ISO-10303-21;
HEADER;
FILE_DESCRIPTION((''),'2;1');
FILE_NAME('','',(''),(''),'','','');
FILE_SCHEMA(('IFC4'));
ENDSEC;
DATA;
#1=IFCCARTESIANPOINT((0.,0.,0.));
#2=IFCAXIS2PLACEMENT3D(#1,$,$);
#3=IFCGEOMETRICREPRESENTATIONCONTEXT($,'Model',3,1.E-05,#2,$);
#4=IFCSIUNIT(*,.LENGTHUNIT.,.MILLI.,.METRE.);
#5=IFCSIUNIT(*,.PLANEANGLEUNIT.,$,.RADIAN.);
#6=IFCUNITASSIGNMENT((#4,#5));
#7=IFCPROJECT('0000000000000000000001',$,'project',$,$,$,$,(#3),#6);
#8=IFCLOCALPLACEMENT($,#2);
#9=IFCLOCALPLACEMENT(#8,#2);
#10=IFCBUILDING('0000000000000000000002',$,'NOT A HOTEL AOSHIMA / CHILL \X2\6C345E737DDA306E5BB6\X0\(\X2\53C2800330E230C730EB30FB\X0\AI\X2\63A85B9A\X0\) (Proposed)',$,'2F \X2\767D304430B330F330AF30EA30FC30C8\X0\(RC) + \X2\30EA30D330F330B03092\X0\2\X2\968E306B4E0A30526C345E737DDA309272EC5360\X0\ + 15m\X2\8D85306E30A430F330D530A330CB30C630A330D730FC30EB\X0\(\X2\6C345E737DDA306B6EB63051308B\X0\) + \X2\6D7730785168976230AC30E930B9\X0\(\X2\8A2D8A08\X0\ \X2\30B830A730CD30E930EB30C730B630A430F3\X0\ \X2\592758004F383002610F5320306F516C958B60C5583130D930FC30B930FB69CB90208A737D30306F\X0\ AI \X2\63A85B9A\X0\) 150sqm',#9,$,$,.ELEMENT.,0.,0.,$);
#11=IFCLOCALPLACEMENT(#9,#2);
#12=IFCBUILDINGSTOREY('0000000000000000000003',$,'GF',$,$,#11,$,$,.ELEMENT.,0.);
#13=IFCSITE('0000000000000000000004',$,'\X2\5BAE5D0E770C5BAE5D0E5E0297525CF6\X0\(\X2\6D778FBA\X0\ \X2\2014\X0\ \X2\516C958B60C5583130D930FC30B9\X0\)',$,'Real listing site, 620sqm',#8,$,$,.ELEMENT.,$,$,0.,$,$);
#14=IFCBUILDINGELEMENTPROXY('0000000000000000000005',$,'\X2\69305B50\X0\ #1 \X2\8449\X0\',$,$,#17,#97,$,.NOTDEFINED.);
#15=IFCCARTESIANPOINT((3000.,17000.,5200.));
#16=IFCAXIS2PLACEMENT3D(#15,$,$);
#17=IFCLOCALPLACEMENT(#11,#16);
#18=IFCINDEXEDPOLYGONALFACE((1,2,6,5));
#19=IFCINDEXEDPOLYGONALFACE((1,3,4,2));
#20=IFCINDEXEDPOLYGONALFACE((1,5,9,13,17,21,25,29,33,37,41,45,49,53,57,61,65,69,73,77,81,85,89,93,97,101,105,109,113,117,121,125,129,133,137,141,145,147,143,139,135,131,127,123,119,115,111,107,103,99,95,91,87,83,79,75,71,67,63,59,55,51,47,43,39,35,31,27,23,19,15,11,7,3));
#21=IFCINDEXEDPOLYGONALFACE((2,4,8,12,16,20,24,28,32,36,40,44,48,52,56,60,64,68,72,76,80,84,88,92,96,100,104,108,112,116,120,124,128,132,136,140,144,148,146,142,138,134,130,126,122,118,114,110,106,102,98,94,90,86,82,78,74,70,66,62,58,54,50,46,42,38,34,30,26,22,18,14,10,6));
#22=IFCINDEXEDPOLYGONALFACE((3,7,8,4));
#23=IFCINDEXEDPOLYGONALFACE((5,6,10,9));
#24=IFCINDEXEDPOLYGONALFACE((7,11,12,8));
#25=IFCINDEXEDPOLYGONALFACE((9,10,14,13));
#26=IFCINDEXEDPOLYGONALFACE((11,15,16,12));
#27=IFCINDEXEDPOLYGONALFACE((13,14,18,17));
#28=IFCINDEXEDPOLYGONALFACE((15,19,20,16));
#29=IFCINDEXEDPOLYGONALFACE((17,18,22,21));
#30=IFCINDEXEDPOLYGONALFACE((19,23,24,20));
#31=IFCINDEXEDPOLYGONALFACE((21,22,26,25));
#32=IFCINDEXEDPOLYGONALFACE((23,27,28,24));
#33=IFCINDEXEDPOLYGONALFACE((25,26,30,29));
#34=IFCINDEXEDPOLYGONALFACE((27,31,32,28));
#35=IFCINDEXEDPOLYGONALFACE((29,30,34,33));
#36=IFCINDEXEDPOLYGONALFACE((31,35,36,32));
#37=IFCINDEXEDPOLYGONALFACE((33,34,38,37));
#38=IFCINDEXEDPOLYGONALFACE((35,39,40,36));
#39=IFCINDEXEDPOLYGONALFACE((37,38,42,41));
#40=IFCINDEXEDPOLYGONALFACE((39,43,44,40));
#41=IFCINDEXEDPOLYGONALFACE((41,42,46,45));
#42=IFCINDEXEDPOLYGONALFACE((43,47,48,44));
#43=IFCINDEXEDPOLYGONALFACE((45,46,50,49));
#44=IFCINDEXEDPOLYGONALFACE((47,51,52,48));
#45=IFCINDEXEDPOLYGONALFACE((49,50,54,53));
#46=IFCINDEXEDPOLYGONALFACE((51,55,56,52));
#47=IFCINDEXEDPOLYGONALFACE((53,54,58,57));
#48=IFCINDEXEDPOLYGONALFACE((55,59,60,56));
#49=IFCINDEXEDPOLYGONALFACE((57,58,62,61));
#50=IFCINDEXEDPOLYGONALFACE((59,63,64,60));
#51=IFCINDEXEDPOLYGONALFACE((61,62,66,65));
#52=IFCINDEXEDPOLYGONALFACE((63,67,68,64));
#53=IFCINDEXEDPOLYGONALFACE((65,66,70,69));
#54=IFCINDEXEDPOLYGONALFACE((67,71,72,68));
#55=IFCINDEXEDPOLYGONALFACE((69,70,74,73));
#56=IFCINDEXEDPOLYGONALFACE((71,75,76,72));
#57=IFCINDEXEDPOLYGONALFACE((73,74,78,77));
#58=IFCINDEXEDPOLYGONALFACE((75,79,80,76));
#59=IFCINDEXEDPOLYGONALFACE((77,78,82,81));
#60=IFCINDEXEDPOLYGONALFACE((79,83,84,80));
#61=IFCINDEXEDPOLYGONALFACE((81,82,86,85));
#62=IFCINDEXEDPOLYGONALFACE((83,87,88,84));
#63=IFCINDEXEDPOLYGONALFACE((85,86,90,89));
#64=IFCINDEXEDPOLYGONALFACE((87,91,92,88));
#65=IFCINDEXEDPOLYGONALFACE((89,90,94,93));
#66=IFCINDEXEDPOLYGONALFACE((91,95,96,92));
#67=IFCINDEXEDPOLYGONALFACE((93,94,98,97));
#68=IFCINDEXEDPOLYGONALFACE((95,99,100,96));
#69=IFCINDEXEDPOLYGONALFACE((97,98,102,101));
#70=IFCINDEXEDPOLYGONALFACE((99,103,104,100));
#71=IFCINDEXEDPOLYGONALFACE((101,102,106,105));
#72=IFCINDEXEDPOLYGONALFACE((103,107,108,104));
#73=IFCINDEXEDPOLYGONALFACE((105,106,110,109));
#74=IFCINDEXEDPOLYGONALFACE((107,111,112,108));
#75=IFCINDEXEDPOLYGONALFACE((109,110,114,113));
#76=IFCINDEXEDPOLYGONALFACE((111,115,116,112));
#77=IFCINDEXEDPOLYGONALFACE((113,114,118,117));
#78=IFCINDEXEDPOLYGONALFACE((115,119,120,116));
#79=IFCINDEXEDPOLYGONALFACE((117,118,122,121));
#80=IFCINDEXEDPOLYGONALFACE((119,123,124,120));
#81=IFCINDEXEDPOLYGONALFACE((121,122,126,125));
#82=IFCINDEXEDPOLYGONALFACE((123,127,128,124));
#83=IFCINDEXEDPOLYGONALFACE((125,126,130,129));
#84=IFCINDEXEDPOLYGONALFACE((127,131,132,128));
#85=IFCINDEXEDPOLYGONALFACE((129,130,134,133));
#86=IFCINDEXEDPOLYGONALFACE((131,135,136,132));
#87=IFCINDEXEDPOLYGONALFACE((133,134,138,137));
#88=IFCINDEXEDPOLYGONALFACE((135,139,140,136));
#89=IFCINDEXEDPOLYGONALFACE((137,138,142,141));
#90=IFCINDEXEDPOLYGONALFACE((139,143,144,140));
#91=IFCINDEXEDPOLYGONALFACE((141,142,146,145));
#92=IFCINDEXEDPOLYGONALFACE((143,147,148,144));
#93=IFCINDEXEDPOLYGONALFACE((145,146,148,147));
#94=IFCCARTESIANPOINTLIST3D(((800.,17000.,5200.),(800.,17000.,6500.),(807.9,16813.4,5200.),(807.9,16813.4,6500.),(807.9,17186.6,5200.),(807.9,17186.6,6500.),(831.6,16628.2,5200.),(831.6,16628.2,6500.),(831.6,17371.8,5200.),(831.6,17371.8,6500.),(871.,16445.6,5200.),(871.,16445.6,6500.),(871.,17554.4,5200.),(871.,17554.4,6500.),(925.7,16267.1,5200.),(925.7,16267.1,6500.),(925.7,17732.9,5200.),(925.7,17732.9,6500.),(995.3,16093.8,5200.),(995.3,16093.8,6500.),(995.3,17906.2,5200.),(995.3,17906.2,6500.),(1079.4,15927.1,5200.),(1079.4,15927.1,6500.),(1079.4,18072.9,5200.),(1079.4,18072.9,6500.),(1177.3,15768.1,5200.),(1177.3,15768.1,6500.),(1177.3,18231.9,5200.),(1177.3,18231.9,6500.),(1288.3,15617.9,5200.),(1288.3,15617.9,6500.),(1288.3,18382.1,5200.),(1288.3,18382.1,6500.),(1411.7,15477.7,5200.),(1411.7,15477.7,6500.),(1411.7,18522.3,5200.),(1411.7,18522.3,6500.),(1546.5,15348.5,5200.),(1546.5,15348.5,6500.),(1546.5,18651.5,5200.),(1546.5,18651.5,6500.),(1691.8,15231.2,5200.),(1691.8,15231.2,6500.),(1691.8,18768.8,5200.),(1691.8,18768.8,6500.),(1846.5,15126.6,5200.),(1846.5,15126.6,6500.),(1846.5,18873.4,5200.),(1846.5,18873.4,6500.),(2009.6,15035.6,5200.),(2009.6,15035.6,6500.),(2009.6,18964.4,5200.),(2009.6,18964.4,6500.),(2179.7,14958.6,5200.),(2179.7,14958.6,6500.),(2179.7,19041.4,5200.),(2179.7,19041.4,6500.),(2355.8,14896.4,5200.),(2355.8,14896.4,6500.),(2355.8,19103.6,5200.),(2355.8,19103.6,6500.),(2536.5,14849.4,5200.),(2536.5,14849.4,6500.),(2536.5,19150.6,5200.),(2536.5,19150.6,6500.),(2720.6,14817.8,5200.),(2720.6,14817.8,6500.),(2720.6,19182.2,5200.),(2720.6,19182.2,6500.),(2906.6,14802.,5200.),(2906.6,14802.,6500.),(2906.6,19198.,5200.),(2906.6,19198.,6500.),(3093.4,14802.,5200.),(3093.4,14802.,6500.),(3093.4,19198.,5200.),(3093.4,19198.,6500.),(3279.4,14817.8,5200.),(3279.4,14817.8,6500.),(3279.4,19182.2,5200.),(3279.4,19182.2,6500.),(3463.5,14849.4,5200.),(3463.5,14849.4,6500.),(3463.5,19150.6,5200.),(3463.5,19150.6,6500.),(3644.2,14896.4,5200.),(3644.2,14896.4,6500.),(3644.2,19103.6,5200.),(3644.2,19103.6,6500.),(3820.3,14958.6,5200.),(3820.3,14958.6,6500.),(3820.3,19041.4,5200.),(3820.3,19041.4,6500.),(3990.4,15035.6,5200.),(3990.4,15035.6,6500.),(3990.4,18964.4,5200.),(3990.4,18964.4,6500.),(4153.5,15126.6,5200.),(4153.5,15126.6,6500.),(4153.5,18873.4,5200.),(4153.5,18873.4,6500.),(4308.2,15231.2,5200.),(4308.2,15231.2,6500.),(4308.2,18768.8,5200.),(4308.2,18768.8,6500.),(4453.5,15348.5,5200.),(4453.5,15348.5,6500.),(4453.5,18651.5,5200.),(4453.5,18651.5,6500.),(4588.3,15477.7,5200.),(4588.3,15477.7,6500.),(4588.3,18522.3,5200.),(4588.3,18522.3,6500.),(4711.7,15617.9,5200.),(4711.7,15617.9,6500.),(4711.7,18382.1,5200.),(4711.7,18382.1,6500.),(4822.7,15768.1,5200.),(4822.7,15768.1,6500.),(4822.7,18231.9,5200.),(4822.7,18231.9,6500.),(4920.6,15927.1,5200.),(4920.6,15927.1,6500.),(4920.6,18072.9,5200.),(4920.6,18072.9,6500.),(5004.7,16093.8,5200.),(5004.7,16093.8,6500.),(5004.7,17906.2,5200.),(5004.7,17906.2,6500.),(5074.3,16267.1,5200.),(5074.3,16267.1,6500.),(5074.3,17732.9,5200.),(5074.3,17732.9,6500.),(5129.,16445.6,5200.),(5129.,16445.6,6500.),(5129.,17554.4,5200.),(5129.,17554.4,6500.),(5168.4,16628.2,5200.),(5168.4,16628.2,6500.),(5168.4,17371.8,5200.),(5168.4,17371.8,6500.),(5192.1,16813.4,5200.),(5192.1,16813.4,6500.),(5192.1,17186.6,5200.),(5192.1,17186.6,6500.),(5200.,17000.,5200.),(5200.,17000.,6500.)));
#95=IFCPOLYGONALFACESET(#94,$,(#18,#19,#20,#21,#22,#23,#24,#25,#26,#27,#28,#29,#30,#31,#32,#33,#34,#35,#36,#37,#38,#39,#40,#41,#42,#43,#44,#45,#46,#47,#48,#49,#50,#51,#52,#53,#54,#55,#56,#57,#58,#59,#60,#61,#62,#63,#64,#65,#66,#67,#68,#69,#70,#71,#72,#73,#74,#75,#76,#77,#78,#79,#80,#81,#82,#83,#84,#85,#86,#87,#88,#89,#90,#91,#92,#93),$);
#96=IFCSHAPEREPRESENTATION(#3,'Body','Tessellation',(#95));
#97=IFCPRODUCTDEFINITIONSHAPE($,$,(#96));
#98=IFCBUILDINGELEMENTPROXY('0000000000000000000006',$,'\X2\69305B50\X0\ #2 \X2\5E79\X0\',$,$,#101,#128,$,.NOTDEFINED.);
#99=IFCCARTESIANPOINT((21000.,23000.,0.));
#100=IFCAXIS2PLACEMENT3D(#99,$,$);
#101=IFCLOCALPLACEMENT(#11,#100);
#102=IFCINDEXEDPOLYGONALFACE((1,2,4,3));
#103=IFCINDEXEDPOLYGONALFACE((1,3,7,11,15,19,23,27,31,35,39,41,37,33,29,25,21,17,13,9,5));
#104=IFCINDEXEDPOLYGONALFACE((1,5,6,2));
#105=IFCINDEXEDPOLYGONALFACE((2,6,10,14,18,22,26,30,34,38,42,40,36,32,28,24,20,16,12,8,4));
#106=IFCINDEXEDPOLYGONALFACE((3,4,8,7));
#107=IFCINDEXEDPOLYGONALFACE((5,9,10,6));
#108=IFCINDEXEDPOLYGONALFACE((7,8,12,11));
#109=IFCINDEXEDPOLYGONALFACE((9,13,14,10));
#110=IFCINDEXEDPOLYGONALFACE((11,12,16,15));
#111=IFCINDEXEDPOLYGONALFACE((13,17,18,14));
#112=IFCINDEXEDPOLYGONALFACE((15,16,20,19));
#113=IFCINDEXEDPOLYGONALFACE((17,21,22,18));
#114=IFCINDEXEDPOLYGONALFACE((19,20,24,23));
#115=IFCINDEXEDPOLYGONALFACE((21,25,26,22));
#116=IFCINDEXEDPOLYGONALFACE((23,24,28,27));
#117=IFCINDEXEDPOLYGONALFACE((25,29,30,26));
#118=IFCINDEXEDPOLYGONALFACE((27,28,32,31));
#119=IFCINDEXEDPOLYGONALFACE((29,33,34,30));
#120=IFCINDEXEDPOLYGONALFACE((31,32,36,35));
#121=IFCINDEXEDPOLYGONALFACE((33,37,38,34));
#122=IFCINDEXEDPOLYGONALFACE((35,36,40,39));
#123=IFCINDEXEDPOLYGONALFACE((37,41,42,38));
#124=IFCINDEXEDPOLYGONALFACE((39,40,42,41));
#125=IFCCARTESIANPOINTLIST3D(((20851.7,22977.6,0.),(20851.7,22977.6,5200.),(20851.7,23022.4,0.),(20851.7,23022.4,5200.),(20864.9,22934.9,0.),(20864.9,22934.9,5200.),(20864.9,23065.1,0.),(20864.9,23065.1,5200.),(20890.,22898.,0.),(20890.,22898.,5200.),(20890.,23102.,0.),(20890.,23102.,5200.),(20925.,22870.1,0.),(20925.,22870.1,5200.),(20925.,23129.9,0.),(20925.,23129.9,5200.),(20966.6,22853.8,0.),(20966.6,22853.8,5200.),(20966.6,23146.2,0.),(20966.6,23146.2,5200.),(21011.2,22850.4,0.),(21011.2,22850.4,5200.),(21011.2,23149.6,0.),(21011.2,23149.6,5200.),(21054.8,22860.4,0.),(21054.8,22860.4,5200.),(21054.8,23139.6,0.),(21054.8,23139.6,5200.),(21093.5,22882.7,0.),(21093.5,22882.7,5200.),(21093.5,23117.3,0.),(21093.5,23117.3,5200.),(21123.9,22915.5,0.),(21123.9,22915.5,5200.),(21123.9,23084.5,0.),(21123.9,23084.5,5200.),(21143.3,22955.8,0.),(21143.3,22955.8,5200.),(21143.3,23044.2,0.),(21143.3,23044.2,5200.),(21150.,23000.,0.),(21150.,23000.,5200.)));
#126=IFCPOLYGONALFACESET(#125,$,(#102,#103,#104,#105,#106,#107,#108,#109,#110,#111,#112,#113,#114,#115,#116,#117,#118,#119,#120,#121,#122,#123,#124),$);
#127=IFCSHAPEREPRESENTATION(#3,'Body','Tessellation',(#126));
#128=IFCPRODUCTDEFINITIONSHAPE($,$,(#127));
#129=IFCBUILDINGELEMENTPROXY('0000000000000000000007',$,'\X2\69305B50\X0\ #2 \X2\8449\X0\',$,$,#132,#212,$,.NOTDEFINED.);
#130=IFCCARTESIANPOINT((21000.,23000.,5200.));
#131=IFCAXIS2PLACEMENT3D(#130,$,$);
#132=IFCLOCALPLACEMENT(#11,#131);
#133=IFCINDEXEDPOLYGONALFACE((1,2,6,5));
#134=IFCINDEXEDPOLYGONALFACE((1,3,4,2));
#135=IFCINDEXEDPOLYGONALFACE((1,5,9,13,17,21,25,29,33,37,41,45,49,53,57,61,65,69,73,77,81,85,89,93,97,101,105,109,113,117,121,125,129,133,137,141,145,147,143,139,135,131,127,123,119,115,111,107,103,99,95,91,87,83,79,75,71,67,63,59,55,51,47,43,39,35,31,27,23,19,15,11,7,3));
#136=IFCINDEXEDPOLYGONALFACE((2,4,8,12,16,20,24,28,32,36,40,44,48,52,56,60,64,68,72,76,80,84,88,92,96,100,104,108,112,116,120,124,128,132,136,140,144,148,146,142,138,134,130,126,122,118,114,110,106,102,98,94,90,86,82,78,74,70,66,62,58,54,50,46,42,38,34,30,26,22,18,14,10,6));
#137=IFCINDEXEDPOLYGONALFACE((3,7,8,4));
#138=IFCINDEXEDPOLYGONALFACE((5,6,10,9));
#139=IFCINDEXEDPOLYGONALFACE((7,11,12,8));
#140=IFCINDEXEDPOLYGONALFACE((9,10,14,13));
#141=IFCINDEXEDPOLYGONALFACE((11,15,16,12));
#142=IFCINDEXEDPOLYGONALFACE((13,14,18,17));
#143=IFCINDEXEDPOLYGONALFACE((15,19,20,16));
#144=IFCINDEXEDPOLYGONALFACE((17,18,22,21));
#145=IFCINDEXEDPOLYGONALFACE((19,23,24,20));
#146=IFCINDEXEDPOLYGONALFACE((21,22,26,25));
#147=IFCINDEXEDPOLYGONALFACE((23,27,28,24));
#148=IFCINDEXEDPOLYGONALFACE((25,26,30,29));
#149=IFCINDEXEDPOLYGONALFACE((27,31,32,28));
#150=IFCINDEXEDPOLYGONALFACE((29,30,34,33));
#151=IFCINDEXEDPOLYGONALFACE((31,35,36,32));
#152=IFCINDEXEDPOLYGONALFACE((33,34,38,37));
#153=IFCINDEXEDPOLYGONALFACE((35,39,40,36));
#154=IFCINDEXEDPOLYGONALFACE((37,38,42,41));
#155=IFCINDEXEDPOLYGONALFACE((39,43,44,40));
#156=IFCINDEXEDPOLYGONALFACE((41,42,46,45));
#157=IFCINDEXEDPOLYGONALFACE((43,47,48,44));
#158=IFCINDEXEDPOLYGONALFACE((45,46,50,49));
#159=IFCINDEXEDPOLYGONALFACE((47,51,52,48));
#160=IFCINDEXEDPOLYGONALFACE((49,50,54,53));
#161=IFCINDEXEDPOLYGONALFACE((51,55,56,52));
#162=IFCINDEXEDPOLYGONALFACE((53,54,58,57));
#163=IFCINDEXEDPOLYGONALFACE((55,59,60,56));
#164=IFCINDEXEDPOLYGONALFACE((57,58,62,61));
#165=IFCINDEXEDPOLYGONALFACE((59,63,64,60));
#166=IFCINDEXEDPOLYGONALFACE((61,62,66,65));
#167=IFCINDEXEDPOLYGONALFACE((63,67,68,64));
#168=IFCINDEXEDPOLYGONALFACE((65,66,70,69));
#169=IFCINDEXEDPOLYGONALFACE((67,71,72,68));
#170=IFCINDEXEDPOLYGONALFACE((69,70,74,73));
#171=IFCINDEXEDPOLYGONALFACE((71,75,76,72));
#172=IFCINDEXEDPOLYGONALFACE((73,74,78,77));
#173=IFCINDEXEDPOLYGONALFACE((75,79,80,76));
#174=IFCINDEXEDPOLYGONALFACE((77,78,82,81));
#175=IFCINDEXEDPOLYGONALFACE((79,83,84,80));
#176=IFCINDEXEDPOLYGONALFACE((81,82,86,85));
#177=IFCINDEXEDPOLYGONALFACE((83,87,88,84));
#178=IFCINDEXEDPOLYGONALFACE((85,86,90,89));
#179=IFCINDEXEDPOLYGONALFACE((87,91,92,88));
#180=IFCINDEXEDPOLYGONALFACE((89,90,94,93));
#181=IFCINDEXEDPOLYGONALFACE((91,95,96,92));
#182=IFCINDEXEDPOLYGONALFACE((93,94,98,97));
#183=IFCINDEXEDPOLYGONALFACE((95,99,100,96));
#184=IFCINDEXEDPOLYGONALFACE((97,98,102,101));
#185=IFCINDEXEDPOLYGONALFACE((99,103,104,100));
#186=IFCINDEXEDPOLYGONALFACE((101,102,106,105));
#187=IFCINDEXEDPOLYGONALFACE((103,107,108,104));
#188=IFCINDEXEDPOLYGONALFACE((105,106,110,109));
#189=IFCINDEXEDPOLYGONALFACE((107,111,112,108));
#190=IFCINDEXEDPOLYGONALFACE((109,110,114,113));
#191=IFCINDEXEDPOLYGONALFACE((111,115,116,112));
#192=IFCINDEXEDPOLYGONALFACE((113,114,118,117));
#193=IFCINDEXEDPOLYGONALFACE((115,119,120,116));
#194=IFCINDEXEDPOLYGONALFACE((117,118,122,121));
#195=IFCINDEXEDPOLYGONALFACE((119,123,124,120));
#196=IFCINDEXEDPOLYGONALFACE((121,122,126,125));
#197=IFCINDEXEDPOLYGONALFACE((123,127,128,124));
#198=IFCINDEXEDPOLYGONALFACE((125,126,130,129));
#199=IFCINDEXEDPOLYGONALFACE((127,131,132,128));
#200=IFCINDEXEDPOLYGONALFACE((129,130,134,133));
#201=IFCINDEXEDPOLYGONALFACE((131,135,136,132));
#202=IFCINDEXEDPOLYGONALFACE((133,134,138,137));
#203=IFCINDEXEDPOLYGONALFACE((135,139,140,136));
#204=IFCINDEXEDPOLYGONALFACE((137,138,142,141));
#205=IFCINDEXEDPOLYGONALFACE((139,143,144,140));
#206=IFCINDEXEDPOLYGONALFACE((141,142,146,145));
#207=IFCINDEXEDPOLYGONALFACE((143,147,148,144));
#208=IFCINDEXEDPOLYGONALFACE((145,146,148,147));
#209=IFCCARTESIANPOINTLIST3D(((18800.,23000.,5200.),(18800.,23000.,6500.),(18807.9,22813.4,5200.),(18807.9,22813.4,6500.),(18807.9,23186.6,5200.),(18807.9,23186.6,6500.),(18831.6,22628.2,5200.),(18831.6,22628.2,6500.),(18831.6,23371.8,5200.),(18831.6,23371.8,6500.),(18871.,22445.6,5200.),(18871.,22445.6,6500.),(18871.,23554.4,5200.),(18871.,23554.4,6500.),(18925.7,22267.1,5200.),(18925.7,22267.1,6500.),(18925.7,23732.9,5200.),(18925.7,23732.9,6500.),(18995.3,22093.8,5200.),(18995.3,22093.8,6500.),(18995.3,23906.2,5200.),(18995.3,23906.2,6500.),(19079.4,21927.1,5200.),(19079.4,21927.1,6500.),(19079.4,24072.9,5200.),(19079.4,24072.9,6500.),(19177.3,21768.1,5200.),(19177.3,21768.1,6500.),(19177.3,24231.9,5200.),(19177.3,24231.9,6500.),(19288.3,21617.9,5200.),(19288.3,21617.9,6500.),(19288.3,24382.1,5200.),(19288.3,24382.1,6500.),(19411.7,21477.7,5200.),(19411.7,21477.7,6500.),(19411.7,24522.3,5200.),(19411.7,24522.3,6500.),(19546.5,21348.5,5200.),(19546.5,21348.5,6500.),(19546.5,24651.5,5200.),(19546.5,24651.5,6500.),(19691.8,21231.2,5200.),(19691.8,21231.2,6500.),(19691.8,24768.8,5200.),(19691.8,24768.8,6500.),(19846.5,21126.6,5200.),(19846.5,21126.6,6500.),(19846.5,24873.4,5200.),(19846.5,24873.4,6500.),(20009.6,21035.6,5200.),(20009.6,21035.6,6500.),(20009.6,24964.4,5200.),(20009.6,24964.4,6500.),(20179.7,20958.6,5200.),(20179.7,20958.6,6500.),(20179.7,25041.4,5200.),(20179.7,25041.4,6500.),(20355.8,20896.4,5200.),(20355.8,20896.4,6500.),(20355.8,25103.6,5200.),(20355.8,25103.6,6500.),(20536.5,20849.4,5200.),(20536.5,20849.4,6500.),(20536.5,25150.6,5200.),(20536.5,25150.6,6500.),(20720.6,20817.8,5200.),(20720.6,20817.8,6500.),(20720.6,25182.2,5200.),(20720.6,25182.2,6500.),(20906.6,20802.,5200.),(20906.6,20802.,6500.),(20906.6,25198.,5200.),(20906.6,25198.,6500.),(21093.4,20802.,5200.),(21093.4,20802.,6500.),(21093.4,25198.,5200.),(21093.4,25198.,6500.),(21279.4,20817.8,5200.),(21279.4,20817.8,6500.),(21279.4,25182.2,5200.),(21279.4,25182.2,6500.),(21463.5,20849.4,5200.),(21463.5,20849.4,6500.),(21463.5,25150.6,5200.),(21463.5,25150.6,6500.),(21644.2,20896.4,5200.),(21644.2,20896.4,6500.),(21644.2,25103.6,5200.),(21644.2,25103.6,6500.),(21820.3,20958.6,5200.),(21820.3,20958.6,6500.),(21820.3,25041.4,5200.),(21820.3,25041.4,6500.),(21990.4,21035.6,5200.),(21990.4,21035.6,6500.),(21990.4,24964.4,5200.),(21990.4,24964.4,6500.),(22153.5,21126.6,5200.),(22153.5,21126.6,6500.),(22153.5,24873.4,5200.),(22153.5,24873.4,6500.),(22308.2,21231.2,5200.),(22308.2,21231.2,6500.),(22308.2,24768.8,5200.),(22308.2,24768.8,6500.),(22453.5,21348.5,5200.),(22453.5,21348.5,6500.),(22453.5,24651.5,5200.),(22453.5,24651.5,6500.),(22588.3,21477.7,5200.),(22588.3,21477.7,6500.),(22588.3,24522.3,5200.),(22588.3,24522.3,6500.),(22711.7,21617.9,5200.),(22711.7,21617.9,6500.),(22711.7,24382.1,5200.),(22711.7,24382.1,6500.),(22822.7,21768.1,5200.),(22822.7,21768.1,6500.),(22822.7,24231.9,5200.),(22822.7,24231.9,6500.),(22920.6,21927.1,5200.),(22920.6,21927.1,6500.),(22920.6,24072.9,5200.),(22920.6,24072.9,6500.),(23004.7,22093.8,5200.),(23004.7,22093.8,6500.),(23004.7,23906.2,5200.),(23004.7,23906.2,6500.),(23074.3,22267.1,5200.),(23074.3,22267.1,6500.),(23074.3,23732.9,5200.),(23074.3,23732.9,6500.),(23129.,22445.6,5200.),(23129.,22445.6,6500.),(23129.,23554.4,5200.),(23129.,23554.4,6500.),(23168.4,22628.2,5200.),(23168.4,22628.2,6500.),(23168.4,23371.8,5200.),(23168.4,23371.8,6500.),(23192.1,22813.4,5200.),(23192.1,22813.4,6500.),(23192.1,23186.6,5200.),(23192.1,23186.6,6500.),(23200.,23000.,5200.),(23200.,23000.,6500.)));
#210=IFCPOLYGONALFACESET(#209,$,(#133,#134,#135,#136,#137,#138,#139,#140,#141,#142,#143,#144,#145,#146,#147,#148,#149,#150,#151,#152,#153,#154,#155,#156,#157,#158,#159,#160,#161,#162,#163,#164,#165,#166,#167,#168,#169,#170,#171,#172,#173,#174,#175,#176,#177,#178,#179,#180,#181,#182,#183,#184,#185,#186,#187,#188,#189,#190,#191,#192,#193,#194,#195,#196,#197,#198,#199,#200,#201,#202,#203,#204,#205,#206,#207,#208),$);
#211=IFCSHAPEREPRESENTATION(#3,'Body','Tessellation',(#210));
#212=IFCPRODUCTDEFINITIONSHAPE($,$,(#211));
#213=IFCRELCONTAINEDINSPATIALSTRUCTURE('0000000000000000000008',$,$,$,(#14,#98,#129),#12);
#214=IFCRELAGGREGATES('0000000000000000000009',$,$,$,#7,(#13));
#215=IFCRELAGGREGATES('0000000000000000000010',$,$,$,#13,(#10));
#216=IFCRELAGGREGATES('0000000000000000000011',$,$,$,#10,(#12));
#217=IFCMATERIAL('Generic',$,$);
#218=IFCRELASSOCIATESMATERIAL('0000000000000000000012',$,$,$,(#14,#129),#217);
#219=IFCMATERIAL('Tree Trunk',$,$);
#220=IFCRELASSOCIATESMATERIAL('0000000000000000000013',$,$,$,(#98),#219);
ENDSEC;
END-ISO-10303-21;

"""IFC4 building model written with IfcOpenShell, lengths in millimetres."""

from ifc_helpers import new_model, si_unit, frame, origin, origin_2d, place, context, project, spatial, circle, extrude, material, element, save


model = new_model("IFC4")

# Units and contexts
model_context = context("Model", 3, precision=1e-05, world=origin())
ifc_project = project(units=[si_unit("LENGTHUNIT", "METRE", prefix="MILLI"), si_unit("PLANEANGLEUNIT", "RADIAN")], contexts=[model_context])

# Site, building, storey
site_placement = place(None, origin())
site = spatial("IfcSite", under=ifc_project, at=site_placement, Name="宮崎県宮崎市青島(海辺 — 公開情報ベース)", ObjectType="Real listing site, 620sqm", CompositionType="ELEMENT", RefElevation=0.0)
building_placement = place(site_placement, origin())
building = spatial("IfcBuilding", under=site, at=building_placement, Name="NOT A HOTEL AOSHIMA / CHILL 水平線の家(参考モデル・AI推定) (Proposed)", ObjectType="2F 白いコンクリート(RC) + リビングを2階に上げ水平線を独占 + 15m超のインフィニティプール(水平線に溶ける) + 海へ全面ガラス(設計 ジェネラルデザイン 大堀伸。意匠は公開情報ベース・構造詳細は AI 推定) 150sqm", CompositionType="ELEMENT", ElevationOfRefHeight=0.0, ElevationOfTerrain=0.0)
storey_placement = place(building_placement, origin())
storey = spatial("IfcBuildingStorey", under=building, at=storey_placement, Name="GF", CompositionType="ELEMENT", Elevation=0.0)

# Shared definitions
ifc_material_1 = material(Name="Generic")

# Building element proxies
ifc_material_2 = material(Name="Tree Trunk")
proxy_1_placement = place(storey_placement, frame((3000.0, 17000.0, 5200.0)))
element("IfcBuildingElementProxy", 1, at=proxy_1_placement, inside=storey, material=ifc_material_1, Name="椰子 #1 葉", PredefinedType="NOTDEFINED", context=model_context, shape_type="SweptSolid", body=[
    extrude(circle(Radius=2200.0, at=origin_2d()), frame((3000.0, 17000.0, 5200.0)), (0.0, 0.0, 1.0), 1300.0),
])
proxy_2_placement = place(storey_placement, frame((21000.0, 23000.0, 0.0)))
element("IfcBuildingElementProxy", 2, at=proxy_2_placement, inside=storey, material=ifc_material_2, Name="椰子 #2 幹", PredefinedType="NOTDEFINED", context=model_context, shape_type="SweptSolid", body=[
    extrude(circle(Radius=150.0, at=origin_2d()), frame((21000.0, 23000.0, 0.0)), (0.0, 0.0, 1.0), 5200.0),
])
proxy_3_placement = place(storey_placement, frame((21000.0, 23000.0, 5200.0)))
element("IfcBuildingElementProxy", 3, at=proxy_3_placement, inside=storey, material=ifc_material_1, Name="椰子 #2 葉", PredefinedType="NOTDEFINED", context=model_context, shape_type="SweptSolid", body=[
    extrude(circle(Radius=2200.0, at=origin_2d()), frame((21000.0, 23000.0, 5200.0)), (0.0, 0.0, 1.0), 1300.0),
])

save(model, "model.ifc")
